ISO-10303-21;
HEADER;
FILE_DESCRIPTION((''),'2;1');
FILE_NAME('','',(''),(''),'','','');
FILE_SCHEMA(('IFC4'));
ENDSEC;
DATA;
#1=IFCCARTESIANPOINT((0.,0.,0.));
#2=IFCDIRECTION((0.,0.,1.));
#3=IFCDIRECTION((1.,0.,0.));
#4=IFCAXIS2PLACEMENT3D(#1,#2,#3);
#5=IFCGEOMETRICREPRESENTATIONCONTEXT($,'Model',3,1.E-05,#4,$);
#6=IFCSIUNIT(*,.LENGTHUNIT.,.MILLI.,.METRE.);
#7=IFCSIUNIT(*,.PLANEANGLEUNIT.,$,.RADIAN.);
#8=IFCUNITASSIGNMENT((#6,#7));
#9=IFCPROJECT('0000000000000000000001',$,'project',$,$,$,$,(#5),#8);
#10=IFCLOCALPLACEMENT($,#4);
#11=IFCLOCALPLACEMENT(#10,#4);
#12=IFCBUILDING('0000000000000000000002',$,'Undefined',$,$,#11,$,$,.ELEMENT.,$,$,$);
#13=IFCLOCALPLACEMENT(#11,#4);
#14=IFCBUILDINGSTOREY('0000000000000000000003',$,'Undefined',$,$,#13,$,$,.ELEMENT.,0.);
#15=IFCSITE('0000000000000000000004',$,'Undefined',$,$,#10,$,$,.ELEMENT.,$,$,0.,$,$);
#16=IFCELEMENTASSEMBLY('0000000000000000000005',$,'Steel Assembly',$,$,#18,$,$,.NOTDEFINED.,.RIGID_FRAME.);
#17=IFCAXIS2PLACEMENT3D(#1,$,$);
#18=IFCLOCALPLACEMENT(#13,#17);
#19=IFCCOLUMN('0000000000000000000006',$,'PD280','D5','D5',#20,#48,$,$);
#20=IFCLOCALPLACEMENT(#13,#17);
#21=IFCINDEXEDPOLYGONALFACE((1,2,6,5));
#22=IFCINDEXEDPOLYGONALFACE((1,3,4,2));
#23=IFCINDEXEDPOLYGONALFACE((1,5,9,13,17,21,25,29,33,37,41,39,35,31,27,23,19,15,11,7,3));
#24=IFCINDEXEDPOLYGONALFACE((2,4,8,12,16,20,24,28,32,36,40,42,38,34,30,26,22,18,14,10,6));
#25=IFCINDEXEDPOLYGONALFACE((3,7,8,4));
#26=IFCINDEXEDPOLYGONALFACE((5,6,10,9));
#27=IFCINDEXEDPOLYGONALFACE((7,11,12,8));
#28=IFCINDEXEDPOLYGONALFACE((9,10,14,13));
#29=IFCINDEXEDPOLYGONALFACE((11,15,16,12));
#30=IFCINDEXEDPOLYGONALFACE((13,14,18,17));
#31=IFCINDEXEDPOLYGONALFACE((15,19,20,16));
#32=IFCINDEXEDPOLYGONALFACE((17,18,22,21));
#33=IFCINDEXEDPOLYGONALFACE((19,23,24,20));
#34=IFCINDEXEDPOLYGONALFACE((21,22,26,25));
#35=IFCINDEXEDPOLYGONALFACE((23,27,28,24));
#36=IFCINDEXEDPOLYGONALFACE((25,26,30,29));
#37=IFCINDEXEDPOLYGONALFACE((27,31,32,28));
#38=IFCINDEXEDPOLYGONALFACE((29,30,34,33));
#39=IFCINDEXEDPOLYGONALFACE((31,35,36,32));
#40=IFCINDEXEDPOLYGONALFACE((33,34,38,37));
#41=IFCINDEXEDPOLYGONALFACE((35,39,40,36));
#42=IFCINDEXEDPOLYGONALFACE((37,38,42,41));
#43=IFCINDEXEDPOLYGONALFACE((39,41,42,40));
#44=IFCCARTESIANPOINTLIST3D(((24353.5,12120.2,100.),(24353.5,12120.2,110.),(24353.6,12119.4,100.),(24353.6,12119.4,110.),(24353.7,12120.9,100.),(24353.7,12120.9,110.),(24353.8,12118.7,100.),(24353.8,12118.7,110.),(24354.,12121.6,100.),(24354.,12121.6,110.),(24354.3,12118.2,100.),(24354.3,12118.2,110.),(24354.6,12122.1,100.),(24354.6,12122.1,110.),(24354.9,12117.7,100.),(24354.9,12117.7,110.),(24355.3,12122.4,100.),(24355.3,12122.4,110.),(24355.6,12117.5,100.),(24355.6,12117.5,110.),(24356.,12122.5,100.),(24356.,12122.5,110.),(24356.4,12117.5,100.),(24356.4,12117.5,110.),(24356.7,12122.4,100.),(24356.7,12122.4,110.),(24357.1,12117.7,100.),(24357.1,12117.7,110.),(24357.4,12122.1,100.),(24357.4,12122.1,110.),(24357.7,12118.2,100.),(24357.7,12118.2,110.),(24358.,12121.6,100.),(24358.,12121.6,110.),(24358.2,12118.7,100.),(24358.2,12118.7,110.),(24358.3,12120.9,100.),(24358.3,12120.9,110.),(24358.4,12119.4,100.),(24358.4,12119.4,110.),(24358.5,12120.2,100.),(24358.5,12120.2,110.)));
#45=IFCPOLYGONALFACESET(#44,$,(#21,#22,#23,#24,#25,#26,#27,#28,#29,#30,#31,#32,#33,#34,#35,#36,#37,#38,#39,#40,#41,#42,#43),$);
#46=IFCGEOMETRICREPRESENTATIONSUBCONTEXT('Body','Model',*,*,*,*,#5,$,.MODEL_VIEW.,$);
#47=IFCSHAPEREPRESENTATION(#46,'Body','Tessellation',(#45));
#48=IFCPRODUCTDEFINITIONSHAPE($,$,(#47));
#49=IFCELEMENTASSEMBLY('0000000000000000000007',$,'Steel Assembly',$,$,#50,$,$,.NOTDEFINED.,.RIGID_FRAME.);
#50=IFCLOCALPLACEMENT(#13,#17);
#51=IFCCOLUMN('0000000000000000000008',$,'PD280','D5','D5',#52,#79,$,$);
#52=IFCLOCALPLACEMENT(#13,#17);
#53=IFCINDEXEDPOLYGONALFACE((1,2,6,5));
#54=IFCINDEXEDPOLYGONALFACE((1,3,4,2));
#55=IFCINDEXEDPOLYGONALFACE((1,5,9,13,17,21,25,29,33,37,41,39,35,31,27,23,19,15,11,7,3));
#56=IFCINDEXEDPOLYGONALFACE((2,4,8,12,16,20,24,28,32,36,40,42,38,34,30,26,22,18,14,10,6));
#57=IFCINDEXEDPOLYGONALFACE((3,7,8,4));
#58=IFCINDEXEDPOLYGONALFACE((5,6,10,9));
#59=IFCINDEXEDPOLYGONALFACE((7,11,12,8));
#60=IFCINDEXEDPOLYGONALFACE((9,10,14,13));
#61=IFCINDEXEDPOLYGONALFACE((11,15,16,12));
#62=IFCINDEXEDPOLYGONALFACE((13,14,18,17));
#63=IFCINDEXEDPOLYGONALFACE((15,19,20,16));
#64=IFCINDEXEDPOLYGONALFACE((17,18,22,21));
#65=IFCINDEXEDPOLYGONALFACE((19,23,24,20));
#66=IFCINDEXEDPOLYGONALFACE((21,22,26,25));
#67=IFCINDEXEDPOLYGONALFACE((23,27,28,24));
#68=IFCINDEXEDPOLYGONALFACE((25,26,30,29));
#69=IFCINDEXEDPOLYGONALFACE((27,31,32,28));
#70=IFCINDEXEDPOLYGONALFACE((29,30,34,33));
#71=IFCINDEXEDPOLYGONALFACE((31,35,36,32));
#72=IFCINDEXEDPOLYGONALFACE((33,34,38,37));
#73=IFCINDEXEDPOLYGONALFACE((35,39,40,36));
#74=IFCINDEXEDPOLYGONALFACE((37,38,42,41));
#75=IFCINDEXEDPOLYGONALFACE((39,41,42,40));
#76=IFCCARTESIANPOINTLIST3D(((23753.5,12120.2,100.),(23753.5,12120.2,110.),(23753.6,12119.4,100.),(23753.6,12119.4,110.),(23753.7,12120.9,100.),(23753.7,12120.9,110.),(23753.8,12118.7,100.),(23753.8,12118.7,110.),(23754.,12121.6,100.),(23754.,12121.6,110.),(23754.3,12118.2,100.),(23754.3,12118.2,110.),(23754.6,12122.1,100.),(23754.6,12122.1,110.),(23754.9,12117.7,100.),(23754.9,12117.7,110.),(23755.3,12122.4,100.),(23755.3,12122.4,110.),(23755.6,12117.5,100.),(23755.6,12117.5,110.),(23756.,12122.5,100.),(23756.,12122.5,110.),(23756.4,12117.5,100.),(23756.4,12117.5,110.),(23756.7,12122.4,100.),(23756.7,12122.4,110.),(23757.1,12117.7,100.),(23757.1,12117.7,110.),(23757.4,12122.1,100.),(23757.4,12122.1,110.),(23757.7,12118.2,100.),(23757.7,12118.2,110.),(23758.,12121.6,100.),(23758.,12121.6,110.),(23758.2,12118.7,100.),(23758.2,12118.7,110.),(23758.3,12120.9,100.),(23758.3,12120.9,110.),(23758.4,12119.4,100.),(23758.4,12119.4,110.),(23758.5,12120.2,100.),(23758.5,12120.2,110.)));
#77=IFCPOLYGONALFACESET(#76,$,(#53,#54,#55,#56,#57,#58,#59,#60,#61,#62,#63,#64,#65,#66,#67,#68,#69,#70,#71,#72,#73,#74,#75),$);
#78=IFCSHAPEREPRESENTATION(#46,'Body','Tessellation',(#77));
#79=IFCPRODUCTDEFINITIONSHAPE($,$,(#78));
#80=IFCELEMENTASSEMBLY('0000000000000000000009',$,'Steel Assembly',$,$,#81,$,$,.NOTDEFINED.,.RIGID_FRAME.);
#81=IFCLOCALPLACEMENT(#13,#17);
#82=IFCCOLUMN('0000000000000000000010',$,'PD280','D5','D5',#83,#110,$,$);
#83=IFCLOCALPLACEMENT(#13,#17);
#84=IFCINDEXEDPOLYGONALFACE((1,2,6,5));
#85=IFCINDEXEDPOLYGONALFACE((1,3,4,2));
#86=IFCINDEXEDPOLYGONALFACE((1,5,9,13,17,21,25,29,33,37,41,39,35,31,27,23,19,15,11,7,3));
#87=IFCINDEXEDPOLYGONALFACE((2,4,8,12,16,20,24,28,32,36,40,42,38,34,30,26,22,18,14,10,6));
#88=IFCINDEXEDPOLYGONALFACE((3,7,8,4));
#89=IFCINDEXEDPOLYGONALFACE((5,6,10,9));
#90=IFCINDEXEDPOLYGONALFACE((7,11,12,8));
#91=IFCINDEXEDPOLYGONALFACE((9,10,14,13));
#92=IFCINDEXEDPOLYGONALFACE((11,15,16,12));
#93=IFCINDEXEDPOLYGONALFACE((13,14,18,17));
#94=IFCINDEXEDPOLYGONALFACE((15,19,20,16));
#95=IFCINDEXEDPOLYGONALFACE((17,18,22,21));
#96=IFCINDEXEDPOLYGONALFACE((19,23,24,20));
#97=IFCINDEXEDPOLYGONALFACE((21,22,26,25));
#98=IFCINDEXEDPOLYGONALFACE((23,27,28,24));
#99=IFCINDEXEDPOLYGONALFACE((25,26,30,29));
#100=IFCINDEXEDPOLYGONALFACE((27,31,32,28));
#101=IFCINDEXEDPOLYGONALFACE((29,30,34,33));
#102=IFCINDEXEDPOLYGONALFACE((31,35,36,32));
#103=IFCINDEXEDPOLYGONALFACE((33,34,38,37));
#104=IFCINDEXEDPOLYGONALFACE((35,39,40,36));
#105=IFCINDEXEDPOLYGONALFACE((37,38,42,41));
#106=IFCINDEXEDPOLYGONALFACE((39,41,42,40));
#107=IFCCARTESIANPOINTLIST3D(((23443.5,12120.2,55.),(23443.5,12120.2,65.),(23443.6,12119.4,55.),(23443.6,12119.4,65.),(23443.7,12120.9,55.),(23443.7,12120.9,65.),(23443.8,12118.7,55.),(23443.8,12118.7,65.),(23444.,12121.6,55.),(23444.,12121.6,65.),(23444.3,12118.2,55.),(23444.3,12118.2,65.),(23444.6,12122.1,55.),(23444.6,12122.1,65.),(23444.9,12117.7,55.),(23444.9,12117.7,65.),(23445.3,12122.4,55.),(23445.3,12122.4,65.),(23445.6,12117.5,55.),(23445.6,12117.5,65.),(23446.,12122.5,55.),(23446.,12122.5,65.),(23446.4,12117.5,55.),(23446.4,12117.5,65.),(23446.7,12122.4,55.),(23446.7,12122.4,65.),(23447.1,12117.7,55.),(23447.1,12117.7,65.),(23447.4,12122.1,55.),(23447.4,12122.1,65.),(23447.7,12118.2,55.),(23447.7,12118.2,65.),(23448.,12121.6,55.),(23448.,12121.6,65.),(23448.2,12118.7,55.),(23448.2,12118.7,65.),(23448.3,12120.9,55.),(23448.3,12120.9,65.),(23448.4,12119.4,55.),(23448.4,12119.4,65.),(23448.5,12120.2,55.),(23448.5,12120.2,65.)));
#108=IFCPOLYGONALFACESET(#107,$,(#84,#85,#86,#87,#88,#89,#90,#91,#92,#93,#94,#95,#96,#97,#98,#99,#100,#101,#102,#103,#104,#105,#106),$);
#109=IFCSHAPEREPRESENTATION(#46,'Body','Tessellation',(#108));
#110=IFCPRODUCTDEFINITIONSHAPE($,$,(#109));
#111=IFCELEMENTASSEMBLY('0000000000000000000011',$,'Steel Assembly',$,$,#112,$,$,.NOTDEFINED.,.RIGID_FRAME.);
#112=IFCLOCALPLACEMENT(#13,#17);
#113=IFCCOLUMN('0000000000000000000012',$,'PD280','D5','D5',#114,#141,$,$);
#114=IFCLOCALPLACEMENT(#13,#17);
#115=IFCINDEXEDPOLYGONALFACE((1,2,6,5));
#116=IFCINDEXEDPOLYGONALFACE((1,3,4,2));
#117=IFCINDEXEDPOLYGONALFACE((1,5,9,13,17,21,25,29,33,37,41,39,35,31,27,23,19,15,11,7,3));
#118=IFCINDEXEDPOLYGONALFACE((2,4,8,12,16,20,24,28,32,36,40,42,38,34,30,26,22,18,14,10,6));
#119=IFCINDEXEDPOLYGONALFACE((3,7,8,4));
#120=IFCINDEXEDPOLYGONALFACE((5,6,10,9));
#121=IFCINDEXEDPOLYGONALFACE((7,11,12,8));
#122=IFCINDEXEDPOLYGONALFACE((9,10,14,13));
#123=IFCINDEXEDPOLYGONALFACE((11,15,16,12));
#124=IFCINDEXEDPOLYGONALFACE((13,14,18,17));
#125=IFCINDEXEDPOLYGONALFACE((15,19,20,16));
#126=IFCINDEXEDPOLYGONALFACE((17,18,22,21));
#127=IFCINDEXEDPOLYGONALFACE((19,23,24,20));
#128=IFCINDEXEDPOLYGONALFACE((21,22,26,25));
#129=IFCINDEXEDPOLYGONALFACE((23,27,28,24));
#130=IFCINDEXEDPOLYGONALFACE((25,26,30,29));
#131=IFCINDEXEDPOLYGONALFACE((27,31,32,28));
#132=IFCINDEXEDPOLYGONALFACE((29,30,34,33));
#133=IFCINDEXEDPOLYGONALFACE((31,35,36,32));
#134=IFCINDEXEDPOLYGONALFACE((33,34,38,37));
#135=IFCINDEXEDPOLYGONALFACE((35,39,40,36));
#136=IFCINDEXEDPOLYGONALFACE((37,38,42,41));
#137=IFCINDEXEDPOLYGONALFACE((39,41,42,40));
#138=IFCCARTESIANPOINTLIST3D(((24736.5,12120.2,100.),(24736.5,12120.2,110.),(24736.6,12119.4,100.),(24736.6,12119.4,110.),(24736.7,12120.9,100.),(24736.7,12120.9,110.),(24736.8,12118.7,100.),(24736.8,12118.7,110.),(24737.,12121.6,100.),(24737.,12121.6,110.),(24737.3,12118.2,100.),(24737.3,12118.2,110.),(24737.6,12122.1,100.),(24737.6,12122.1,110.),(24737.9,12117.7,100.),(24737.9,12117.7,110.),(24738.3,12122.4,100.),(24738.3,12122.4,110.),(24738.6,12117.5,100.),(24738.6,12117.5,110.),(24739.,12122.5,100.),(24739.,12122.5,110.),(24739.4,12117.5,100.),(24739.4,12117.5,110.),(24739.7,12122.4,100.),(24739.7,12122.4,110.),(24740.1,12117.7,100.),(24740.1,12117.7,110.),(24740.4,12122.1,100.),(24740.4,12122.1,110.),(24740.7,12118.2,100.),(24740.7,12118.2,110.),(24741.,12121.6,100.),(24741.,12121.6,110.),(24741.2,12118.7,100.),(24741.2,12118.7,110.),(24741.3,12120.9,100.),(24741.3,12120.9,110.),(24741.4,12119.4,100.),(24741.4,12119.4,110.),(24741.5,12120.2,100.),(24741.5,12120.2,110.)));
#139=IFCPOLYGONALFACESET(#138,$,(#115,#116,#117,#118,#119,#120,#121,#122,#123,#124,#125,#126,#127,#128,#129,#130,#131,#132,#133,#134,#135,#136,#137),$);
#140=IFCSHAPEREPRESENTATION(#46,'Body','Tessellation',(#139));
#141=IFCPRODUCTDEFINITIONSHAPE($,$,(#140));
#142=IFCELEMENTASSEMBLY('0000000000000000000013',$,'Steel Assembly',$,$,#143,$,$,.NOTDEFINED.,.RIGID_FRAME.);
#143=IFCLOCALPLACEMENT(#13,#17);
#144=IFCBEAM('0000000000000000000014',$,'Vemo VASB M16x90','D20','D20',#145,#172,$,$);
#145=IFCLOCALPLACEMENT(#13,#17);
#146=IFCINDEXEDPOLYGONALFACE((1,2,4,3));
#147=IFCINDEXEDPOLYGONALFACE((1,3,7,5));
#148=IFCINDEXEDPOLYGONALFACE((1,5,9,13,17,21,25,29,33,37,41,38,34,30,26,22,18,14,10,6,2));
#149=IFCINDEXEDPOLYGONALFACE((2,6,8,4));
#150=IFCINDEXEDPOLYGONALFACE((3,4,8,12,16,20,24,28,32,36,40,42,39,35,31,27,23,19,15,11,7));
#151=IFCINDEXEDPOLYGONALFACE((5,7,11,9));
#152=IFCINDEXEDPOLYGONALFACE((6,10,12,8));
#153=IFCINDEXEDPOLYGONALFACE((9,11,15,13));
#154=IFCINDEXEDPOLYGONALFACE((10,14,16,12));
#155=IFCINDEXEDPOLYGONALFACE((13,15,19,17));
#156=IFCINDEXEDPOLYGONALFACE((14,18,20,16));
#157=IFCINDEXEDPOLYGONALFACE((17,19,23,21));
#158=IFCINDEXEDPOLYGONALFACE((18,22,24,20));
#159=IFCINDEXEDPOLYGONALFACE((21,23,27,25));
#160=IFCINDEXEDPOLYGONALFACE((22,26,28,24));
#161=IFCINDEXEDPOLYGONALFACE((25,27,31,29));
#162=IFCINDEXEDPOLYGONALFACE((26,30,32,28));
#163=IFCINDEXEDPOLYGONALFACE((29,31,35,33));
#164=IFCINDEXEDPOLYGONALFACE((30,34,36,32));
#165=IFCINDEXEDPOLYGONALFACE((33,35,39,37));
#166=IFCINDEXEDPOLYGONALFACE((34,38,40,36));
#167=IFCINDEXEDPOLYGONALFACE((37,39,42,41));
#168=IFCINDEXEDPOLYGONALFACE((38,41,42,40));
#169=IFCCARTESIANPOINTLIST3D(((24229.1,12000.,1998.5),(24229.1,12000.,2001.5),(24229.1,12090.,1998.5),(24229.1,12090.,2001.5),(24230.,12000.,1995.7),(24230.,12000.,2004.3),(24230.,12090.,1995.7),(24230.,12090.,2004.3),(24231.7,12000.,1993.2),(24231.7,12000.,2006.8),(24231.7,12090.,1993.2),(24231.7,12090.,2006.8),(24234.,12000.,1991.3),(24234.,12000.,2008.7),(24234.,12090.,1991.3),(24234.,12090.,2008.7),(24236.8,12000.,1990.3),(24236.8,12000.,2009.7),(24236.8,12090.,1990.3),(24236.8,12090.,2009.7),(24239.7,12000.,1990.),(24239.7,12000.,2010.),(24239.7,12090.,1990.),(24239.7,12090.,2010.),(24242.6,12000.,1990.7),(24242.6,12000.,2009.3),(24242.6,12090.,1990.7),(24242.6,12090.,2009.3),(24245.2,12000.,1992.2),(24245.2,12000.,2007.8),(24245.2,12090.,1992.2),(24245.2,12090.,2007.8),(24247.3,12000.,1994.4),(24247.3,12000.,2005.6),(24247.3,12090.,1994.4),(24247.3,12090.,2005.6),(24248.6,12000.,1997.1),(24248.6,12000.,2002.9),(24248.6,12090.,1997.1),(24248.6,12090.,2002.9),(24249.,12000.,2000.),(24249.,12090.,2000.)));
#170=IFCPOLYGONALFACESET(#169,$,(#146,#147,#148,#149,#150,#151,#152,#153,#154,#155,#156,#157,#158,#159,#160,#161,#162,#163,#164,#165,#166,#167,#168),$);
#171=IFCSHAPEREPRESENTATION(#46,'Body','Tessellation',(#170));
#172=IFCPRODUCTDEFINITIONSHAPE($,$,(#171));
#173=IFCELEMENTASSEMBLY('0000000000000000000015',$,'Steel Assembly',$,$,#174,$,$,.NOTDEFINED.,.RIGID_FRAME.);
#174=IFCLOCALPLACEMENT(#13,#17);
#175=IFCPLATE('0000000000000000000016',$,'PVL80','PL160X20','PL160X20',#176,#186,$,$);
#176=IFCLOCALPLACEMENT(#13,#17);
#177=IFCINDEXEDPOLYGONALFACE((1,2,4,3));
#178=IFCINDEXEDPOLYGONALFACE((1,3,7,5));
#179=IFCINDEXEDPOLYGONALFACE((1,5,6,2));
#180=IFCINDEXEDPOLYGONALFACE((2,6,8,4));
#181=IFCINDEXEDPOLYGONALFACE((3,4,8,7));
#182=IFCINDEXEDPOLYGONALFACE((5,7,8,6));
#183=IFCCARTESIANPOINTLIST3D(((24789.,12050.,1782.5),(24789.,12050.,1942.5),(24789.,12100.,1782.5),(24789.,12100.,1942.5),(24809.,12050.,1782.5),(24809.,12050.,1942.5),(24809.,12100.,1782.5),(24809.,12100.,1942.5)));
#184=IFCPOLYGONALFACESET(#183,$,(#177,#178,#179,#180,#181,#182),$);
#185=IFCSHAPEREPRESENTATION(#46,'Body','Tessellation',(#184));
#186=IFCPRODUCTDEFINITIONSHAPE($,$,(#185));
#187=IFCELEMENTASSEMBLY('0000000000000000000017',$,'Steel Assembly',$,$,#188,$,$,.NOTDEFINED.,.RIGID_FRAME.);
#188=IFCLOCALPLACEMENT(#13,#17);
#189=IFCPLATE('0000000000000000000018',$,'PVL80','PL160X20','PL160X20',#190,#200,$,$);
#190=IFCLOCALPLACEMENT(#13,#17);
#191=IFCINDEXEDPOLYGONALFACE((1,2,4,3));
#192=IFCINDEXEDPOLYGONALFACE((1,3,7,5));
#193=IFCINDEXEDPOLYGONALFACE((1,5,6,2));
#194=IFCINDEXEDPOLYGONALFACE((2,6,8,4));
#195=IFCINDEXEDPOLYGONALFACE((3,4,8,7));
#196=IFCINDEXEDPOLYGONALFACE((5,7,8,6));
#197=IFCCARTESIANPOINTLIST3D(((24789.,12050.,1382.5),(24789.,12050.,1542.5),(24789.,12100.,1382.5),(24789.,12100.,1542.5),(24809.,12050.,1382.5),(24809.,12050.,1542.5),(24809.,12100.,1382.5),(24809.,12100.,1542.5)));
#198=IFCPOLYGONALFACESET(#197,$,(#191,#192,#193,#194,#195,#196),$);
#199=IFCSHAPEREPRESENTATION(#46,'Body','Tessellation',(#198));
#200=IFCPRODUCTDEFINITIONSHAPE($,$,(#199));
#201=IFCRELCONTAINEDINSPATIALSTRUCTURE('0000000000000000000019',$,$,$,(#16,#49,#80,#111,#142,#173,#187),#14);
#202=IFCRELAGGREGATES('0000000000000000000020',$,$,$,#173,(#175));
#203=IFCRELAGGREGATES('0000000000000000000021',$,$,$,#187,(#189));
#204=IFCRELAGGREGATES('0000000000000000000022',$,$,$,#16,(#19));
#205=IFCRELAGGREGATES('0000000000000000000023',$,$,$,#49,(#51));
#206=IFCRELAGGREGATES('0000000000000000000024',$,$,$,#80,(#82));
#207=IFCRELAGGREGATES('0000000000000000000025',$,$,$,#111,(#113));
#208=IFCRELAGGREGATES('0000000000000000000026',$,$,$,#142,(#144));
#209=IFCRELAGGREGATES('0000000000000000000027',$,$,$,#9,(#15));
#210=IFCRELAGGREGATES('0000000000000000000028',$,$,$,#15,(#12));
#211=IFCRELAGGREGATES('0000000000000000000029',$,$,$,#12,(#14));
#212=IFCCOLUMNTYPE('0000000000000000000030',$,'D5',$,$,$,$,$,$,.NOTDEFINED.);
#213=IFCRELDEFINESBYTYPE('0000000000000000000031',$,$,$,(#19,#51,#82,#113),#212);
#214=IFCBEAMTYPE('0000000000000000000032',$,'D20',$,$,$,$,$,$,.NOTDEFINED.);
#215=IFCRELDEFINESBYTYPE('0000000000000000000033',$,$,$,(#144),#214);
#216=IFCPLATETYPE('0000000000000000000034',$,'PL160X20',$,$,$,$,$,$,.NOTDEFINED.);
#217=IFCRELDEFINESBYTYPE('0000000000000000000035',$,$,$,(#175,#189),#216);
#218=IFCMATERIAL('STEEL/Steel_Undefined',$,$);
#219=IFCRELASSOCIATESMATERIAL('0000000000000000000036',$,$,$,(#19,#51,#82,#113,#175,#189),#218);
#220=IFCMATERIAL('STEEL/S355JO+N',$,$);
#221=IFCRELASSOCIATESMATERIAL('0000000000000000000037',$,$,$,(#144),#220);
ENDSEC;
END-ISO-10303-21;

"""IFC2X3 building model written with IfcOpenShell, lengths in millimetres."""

from ifc_helpers import new_model, si_unit, frame, origin_with_axes, origin_2d_with_axis, place, context, subcontext, project, spatial, polyline, circle, outline, extrude, material, type_object, element, aggregate, save


model = new_model("IFC2X3")

# Units and contexts
model_context = context("Model", 3, precision=1e-05, world=origin_with_axes())
body_context = subcontext(model_context, "Body", "Model", "MODEL_VIEW")
ifc_project = project(units=[si_unit("LENGTHUNIT", "METRE", prefix="MILLI"), si_unit("PLANEANGLEUNIT", "RADIAN")], contexts=[model_context])

# Site, building, storey
site_placement = place(None, origin_with_axes())
site = spatial("IfcSite", under=ifc_project, at=site_placement, Name="Undefined", CompositionType="ELEMENT", RefElevation=0.0)
building_placement = place(site_placement, origin_with_axes())
building = spatial("IfcBuilding", under=site, at=building_placement, Name="Undefined", CompositionType="ELEMENT")
storey_placement = place(building_placement, origin_with_axes())
storey = spatial("IfcBuildingStorey", under=building, at=storey_placement, Name="Undefined", CompositionType="ELEMENT", Elevation=0.0)

# Element assemblies, columns
assembly_1_placement = place(storey_placement, origin_with_axes())
assembly_1 = element("IfcElementAssembly", 1, at=assembly_1_placement, inside=storey, Name="Steel Assembly", AssemblyPlace="NOTDEFINED", PredefinedType="RIGID_FRAME")
ifc_material_1 = material(Name="STEEL/Steel_Undefined")
column_type = type_object("IfcColumnType", Name="D5", PredefinedType="NOTDEFINED")
column_1_placement = place(assembly_1_placement, frame((24356.0, 12120.0, 100.0), z_axis=(0.0, 0.0, 1.0), x_axis=(1.0, 0.0, 0.0)))
column_1 = element("IfcColumn", 2, at=column_1_placement, type_object=column_type, material=ifc_material_1, Name="PD280", Description="D5", ObjectType="D5", context=body_context, shape_type="SweptSolid", body=[
    extrude(circle(Radius=2.5, at=origin_2d_with_axis()), frame((0.0, 0.0, 10.0), z_axis=(0.0, 0.0, -1.0), x_axis=(0.0, 1.0, 0.0)), (0.0, 0.0, 1.0), 10.0),
])
assembly_2_placement = place(storey_placement, origin_with_axes())
assembly_2 = element("IfcElementAssembly", 3, at=assembly_2_placement, inside=storey, Name="Steel Assembly", AssemblyPlace="NOTDEFINED", PredefinedType="RIGID_FRAME")
column_2_placement = place(assembly_2_placement, frame((23756.0, 12120.0, 100.0), z_axis=(0.0, 0.0, 1.0), x_axis=(1.0, 0.0, 0.0)))
column_2 = element("IfcColumn", 4, at=column_2_placement, type_object=column_type, material=ifc_material_1, Name="PD280", Description="D5", ObjectType="D5", context=body_context, shape_type="SweptSolid", body=[
    extrude(circle(Radius=2.5, at=origin_2d_with_axis()), frame((0.0, 0.0, 10.0), z_axis=(0.0, 0.0, -1.0), x_axis=(0.0, 1.0, 0.0)), (0.0, 0.0, 1.0), 10.0),
])
assembly_3_placement = place(storey_placement, origin_with_axes())
assembly_3 = element("IfcElementAssembly", 5, at=assembly_3_placement, inside=storey, Name="Steel Assembly", AssemblyPlace="NOTDEFINED", PredefinedType="RIGID_FRAME")
column_3_placement = place(assembly_3_placement, frame((23446.0, 12120.0, 55.0), z_axis=(0.0, 0.0, 1.0), x_axis=(1.0, 0.0, 0.0)))
column_3 = element("IfcColumn", 6, at=column_3_placement, type_object=column_type, material=ifc_material_1, Name="PD280", Description="D5", ObjectType="D5", context=body_context, shape_type="SweptSolid", body=[
    extrude(circle(Radius=2.5, at=origin_2d_with_axis()), frame((0.0, 0.0, 10.0), z_axis=(0.0, 0.0, -1.0), x_axis=(0.0, 1.0, 0.0)), (0.0, 0.0, 1.0), 10.0),
])
assembly_4_placement = place(storey_placement, origin_with_axes())
assembly_4 = element("IfcElementAssembly", 7, at=assembly_4_placement, inside=storey, Name="Steel Assembly", AssemblyPlace="NOTDEFINED", PredefinedType="RIGID_FRAME")
column_4_placement = place(assembly_4_placement, frame((24739.0, 12120.0, 100.0), z_axis=(0.0, 0.0, 1.0), x_axis=(1.0, 0.0, 0.0)))
column_4 = element("IfcColumn", 8, at=column_4_placement, type_object=column_type, material=ifc_material_1, Name="PD280", Description="D5", ObjectType="D5", context=body_context, shape_type="SweptSolid", body=[
    extrude(circle(Radius=2.5, at=origin_2d_with_axis()), frame((0.0, 0.0, 10.0), z_axis=(0.0, 0.0, -1.0), x_axis=(0.0, 1.0, 0.0)), (0.0, 0.0, 1.0), 10.0),
])

# Element assembly, beam
assembly_5_placement = place(storey_placement, origin_with_axes())
assembly_5 = element("IfcElementAssembly", 9, at=assembly_5_placement, inside=storey, Name="Steel Assembly", AssemblyPlace="NOTDEFINED", PredefinedType="RIGID_FRAME")
ifc_material_2 = material(Name="STEEL/S355JO+N")
beam_type = type_object("IfcBeamType", Name="D20", PredefinedType="NOTDEFINED")
beam_placement = place(assembly_5_placement, frame((24239.0, 12000.0, 2000.0), z_axis=(0.0, 0.0, 1.0), x_axis=(0.0, 1.0, 0.0)))
beam = element("IfcBeam", 10, at=beam_placement, type_object=beam_type, material=ifc_material_2, Name="Vemo VASB M16x90", Description="D20", ObjectType="D20", context=body_context, shape_type="SweptSolid", body=[
    extrude(circle(Radius=10.0, at=origin_2d_with_axis()), frame((90.0, 0.0, 0.0), z_axis=(-1.0, 0.0, 0.0), x_axis=(0.0, -1.0, 0.0)), (0.0, 0.0, 1.0), 90.0),
])

# Element assemblies, plates
assembly_6_placement = place(storey_placement, origin_with_axes())
assembly_6 = element("IfcElementAssembly", 11, at=assembly_6_placement, inside=storey, Name="Steel Assembly", AssemblyPlace="NOTDEFINED", PredefinedType="RIGID_FRAME")
plate_type = type_object("IfcPlateType", Name="PL160X20", PredefinedType="NOTDEFINED")
plate_1_placement = place(assembly_6_placement, frame((24809.0, 12100.0, 1862.5), z_axis=(0.0, 0.0, -1.0), x_axis=(0.0, -1.0, 0.0)))
plate_1 = element("IfcPlate", 12, at=plate_1_placement, type_object=plate_type, material=ifc_material_1, Name="PVL80", Description="PL160X20", ObjectType="PL160X20", context=body_context, shape_type="SweptSolid", body=[
    extrude(outline(polyline([(0.0, 0.0), (50.0, 0.0), (50.0, 20.0), (0.0, 20.0), (0.0, 0.0)])), frame((0.0, 0.0, -80.0), z_axis=(0.0, 0.0, 1.0), x_axis=(1.0, 0.0, 0.0)), (0.0, 0.0, 1.0), 160.0),
])
assembly_7_placement = place(storey_placement, origin_with_axes())
assembly_7 = element("IfcElementAssembly", 13, at=assembly_7_placement, inside=storey, Name="Steel Assembly", AssemblyPlace="NOTDEFINED", PredefinedType="RIGID_FRAME")
plate_2_placement = place(assembly_7_placement, frame((24809.0, 12100.0, 1462.5), z_axis=(0.0, 0.0, -1.0), x_axis=(0.0, -1.0, 0.0)))
plate_2 = element("IfcPlate", 14, at=plate_2_placement, type_object=plate_type, material=ifc_material_1, Name="PVL80", Description="PL160X20", ObjectType="PL160X20", context=body_context, shape_type="SweptSolid", body=[
    extrude(outline(polyline([(0.0, 0.0), (50.0, 0.0), (50.0, 20.0), (0.0, 20.0), (0.0, 0.0)])), frame((0.0, 0.0, -80.0), z_axis=(0.0, 0.0, 1.0), x_axis=(1.0, 0.0, 0.0)), (0.0, 0.0, 1.0), 160.0),
])

aggregate(assembly_6, [plate_1])
aggregate(assembly_7, [plate_2])

aggregate(assembly_1, [column_1])
aggregate(assembly_2, [column_2])
aggregate(assembly_3, [column_3])
aggregate(assembly_4, [column_4])

aggregate(assembly_5, [beam])

save(model, "model.ifc")
